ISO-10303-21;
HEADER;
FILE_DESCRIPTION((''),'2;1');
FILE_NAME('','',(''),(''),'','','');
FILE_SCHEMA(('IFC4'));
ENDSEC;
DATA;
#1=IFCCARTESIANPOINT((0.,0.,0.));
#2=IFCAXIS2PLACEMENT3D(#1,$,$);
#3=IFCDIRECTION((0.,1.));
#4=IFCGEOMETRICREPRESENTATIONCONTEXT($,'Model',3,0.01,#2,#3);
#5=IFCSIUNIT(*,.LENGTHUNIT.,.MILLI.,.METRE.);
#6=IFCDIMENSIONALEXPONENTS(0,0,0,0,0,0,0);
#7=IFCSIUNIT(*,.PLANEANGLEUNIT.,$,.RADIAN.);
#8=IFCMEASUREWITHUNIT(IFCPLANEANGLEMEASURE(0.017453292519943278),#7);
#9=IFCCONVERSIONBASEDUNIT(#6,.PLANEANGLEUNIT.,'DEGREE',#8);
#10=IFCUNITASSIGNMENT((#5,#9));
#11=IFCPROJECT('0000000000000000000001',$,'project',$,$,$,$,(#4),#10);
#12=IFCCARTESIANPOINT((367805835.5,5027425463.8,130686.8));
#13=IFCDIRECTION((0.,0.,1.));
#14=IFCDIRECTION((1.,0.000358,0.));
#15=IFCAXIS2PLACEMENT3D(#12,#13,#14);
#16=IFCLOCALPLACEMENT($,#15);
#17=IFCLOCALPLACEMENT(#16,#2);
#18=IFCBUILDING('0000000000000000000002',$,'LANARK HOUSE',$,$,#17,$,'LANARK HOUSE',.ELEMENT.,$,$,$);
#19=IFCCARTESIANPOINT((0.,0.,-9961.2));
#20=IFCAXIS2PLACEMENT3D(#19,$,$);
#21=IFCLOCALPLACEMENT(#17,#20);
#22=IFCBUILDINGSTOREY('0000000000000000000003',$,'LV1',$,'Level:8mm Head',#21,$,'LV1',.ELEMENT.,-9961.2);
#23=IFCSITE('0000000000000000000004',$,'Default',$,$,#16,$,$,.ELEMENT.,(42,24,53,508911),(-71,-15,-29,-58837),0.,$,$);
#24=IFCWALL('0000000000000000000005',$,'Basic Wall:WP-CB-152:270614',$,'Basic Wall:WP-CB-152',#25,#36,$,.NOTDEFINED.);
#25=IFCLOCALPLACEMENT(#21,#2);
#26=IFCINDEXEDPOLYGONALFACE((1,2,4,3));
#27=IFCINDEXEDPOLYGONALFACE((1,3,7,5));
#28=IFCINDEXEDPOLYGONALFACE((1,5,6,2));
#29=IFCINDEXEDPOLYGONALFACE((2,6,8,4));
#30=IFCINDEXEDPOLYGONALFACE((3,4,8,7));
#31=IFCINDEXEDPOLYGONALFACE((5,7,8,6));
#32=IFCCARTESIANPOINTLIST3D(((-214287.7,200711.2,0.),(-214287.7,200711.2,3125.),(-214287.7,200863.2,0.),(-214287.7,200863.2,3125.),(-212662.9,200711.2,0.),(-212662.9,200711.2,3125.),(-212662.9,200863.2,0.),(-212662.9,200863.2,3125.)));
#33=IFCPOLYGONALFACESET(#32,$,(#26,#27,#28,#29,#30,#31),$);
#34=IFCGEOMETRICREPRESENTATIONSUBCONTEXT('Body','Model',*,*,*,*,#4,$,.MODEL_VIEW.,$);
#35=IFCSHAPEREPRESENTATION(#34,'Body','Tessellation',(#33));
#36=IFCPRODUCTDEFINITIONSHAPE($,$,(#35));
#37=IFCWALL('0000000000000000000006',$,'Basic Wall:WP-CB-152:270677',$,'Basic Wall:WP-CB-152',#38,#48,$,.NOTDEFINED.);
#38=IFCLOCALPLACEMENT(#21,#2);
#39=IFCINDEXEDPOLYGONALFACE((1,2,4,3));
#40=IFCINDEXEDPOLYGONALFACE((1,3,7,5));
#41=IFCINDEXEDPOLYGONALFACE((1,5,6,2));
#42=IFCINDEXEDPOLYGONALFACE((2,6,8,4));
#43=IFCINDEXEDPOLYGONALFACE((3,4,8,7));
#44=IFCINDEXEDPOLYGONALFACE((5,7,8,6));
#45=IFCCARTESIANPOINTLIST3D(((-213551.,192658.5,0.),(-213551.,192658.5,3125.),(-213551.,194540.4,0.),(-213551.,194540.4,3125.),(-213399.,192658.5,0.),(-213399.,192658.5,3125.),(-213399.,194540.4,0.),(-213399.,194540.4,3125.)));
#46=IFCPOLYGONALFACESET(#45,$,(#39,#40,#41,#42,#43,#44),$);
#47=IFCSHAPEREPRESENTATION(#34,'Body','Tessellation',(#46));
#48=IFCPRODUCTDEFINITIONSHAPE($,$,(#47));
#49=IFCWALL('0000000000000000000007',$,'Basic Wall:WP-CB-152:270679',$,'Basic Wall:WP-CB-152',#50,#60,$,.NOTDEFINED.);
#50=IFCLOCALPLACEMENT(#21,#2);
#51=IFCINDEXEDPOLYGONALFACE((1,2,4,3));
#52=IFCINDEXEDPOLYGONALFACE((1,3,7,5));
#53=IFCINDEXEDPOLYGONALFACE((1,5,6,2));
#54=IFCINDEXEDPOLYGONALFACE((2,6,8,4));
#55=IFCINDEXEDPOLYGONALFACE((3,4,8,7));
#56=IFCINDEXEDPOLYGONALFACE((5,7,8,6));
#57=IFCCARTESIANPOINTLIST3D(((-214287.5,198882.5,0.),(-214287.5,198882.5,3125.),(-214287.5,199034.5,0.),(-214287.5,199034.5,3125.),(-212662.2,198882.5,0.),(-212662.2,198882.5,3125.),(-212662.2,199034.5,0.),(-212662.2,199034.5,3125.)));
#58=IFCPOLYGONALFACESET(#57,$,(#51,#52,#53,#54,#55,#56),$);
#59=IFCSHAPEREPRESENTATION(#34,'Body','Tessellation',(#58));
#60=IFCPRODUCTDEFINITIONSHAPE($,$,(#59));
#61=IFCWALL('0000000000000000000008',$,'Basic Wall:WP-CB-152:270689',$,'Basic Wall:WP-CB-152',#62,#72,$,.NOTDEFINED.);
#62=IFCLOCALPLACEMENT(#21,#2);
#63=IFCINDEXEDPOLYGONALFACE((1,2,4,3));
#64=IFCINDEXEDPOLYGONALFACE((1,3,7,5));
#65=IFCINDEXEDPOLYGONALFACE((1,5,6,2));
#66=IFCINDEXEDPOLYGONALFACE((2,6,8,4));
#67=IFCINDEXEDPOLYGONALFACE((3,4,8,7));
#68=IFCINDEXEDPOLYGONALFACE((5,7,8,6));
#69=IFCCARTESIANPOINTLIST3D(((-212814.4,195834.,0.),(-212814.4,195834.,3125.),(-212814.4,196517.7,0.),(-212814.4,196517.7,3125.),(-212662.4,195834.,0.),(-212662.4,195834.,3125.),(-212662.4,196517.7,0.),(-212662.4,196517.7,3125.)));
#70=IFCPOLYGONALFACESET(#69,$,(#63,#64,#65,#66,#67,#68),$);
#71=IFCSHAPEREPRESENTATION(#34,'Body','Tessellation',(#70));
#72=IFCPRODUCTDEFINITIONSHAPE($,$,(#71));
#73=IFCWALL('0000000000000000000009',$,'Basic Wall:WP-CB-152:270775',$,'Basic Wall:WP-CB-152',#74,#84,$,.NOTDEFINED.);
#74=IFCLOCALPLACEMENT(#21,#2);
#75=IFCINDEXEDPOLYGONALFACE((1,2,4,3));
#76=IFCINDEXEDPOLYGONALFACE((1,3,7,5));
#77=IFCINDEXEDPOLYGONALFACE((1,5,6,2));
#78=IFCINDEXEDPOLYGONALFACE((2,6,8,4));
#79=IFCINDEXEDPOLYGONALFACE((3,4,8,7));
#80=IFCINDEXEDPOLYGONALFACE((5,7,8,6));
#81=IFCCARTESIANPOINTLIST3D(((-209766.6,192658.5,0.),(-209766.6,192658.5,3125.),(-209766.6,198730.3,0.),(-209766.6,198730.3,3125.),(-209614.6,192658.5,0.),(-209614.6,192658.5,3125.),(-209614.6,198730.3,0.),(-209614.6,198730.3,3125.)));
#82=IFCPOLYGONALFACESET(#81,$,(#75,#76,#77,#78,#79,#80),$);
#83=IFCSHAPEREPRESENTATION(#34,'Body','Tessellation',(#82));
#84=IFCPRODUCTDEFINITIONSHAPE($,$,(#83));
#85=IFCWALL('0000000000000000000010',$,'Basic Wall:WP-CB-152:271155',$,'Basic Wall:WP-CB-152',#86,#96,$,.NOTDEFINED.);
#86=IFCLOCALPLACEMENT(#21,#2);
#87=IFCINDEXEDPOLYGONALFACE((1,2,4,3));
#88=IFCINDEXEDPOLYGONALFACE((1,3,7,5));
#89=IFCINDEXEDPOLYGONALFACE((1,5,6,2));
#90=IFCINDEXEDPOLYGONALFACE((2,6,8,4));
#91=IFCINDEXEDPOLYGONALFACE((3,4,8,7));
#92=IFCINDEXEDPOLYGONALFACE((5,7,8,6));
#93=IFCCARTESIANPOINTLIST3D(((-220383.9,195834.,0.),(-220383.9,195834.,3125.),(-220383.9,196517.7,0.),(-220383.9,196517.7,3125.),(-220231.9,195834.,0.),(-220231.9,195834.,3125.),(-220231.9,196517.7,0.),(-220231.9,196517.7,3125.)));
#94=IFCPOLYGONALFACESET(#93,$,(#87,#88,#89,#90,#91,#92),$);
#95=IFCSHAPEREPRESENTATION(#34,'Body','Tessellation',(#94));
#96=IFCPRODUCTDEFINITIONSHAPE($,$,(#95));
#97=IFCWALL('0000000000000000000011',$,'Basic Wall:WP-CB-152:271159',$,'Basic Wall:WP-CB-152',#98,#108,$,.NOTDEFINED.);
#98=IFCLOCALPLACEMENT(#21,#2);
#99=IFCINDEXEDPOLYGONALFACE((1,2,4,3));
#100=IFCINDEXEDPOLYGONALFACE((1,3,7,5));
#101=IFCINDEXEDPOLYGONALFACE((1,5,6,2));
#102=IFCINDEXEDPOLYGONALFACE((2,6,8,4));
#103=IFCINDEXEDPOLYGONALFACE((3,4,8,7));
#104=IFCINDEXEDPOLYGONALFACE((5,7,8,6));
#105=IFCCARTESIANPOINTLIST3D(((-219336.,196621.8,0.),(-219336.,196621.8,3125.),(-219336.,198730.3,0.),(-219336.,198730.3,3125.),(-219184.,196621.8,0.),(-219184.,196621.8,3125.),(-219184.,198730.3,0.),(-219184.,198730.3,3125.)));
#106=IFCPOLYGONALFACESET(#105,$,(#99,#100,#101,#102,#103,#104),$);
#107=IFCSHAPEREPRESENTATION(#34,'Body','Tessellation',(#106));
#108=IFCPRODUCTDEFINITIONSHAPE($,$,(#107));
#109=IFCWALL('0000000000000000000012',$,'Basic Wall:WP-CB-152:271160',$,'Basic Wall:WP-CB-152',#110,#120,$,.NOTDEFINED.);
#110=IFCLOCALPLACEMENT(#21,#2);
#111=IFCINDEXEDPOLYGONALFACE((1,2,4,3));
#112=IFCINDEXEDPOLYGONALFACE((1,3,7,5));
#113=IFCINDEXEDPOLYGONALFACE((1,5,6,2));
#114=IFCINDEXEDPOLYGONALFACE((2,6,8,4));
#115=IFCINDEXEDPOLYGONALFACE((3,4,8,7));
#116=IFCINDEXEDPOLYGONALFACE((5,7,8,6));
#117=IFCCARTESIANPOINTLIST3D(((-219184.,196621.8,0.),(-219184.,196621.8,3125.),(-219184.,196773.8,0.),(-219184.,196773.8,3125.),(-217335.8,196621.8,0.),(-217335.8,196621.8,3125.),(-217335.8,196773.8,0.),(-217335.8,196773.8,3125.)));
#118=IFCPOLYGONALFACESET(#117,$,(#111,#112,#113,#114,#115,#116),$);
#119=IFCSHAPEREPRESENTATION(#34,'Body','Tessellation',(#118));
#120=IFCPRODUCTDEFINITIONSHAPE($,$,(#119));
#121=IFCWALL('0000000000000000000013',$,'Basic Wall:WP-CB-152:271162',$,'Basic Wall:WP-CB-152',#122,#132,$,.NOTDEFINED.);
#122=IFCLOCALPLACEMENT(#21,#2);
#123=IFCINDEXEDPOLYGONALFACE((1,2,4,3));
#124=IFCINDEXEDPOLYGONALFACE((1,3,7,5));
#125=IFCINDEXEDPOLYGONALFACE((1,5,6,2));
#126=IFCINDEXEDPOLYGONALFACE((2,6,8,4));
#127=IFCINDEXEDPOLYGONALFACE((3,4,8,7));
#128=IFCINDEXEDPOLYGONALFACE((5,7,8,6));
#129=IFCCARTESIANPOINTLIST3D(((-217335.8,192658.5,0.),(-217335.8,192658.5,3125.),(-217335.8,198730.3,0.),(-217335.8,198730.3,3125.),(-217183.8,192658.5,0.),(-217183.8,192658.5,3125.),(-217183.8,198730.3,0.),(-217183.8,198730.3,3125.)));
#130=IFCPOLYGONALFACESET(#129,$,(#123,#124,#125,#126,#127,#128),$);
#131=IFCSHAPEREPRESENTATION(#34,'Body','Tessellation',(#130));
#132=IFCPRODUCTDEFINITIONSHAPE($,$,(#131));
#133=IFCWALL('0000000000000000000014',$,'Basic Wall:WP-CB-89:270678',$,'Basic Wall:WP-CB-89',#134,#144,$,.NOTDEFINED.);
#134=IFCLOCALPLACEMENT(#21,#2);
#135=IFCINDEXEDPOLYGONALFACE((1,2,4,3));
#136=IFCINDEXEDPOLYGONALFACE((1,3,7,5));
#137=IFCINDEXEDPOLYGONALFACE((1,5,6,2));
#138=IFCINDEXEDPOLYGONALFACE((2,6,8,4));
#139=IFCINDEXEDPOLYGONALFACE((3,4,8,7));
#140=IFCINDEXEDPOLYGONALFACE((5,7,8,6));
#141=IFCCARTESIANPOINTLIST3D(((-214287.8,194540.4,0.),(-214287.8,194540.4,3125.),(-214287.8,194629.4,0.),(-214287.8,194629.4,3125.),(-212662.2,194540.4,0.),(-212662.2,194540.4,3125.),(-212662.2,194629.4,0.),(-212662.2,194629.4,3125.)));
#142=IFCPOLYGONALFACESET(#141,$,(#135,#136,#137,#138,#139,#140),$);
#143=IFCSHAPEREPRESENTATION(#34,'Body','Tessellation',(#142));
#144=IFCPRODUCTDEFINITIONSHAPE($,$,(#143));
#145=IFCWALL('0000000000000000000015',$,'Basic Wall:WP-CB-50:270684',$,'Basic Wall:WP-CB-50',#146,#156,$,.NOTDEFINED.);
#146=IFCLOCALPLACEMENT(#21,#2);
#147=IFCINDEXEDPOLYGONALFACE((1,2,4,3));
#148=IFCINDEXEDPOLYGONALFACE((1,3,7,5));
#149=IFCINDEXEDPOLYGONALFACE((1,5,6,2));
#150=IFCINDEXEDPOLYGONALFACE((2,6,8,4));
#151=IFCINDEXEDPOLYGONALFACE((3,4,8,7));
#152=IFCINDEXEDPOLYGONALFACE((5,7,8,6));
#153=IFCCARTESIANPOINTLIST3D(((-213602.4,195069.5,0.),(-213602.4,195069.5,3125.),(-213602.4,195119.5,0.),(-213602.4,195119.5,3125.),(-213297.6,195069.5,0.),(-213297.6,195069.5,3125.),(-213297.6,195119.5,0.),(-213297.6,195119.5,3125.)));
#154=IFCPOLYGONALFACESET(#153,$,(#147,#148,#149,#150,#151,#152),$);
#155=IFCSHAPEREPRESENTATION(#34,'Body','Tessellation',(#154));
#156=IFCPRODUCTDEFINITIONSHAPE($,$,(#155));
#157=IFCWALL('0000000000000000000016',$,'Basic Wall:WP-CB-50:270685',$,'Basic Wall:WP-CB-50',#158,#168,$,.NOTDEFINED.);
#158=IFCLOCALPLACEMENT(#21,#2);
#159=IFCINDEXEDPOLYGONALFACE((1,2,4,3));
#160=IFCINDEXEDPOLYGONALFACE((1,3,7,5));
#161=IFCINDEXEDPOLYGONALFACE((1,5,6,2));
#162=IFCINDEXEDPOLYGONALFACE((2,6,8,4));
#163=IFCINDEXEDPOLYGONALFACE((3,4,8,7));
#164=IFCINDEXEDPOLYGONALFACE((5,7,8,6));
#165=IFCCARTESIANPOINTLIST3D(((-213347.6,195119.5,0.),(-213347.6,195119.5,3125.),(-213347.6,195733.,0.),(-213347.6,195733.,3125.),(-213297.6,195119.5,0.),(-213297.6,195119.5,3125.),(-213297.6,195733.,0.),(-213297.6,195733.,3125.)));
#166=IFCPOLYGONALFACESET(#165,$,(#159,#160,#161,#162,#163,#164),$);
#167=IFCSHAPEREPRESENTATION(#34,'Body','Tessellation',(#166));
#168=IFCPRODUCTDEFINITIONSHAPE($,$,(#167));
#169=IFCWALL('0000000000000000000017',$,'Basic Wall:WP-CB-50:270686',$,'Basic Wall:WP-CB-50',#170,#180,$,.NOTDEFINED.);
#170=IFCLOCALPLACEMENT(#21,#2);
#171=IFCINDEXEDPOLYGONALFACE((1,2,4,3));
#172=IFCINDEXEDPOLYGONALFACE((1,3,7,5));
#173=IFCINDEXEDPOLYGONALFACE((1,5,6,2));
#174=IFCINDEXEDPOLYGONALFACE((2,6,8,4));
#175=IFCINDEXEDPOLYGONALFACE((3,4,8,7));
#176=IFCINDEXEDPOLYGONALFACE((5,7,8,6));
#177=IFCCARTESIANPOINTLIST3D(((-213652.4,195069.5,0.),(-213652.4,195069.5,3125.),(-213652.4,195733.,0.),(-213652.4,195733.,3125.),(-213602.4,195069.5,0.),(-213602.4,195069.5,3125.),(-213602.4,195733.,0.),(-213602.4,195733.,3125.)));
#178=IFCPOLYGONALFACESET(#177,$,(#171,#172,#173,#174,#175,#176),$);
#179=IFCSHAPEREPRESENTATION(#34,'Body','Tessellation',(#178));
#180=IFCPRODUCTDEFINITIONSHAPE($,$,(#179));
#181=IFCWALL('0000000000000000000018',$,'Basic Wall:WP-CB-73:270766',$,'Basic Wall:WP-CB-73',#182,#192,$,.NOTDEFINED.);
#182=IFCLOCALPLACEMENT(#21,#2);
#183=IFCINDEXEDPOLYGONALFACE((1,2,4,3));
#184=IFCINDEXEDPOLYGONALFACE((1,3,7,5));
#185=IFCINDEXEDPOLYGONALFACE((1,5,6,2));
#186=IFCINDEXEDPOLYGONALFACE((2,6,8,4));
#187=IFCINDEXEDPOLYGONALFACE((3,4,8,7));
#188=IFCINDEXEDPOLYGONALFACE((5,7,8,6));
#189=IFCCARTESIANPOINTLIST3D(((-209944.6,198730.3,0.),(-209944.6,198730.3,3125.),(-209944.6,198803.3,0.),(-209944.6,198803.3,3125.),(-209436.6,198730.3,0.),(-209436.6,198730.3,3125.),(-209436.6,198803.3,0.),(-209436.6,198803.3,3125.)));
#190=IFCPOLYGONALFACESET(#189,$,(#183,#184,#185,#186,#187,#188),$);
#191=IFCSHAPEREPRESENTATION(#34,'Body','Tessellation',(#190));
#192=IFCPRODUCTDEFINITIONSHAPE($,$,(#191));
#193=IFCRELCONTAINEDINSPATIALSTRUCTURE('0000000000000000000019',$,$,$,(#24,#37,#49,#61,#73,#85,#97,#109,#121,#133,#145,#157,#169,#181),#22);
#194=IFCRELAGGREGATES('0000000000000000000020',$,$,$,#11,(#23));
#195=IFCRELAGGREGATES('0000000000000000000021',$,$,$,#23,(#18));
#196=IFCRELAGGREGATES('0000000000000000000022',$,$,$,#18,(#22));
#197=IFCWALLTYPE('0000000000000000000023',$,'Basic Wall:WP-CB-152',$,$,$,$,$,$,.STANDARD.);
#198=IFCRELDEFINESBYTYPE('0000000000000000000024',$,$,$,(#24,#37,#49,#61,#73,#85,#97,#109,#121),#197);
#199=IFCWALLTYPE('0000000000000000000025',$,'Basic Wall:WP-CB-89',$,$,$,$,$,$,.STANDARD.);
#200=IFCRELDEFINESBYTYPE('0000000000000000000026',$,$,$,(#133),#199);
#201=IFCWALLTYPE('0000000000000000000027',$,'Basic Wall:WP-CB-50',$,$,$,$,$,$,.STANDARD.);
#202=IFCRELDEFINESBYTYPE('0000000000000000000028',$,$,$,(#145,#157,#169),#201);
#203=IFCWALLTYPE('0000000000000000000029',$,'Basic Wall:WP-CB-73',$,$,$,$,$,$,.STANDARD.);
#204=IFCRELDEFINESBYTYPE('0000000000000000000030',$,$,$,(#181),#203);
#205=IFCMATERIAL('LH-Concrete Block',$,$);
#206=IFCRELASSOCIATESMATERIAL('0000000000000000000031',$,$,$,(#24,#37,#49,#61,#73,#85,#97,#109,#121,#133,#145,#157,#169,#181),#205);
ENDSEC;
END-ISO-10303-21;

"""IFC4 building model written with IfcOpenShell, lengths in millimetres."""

from ifc_helpers import new_model, entity, si_unit, converted_unit, direction, frame, origin, place, context, subcontext, project, spatial, indexed_curve, outline, extrude, material, type_object, element, save


model = new_model("IFC4")

# Units and contexts
model_context = context("Model", 3, precision=0.01, world=origin(), true_north=direction((0.0, 1.0)))
body_context = subcontext(model_context, "Body", "Model", "MODEL_VIEW")
ifc_project = project(units=[si_unit("LENGTHUNIT", "METRE", prefix="MILLI"), converted_unit("PLANEANGLEUNIT", "DEGREE", entity("IfcPlaneAngleMeasure", 0.017453292519943278), si_unit("PLANEANGLEUNIT", "RADIAN"), dimensions=[0, 0, 0, 0, 0, 0, 0])], contexts=[model_context])

# Site, building, storey
site_placement = place(None, frame((367805835.5, 5027425463.8, 130686.8), z_axis=(0.0, 0.0, 1.0), x_axis=(1.0, 0.000358, 0.0)))
site = spatial("IfcSite", under=ifc_project, at=site_placement, Name="Default", CompositionType="ELEMENT", RefLatitude=(42, 24, 53, 508911), RefLongitude=(-71, -15, -29, -58837), RefElevation=0.0)
building_placement = place(site_placement, origin())
building = spatial("IfcBuilding", under=site, at=building_placement, Name="LANARK HOUSE", LongName="LANARK HOUSE", CompositionType="ELEMENT")
storey_placement = place(building_placement, frame((0.0, 0.0, -9961.2)))
storey = spatial("IfcBuildingStorey", under=building, at=storey_placement, Name="LV1", ObjectType="Level:8mm Head", LongName="LV1", CompositionType="ELEMENT", Elevation=-9961.2)

# Walls
ifc_material_1 = material(Name="LH-Concrete Block")
wall_type_1 = type_object("IfcWallType", Name="Basic Wall:WP-CB-152", PredefinedType="STANDARD")
wall_1_placement = place(storey_placement, frame((-212662.9, 200787.2, 0.0), z_axis=(0.0, 0.0, 1.0), x_axis=(-1.0, 0.0, 0.0)))
element("IfcWall", 1, at=wall_1_placement, inside=storey, type_object=wall_type_1, material=ifc_material_1, Name="Basic Wall:WP-CB-152:270614", ObjectType="Basic Wall:WP-CB-152", PredefinedType="NOTDEFINED", context=body_context, shape_type="SweptSolid", body=[
    extrude(outline(indexed_curve([(1624.7, 76.0), (0.0, 76.0), (0.0, -76.0), (1624.7, -76.0), (1624.7, 76.0)], self_intersect=False)), origin(), (0.0, 0.0, 1.0), 3125.0),
])
wall_2_placement = place(storey_placement, frame((-213475.0, 194540.4, 0.0), z_axis=(0.0, 0.0, 1.0), x_axis=(0.0, -1.0, 0.0)))
element("IfcWall", 2, at=wall_2_placement, inside=storey, type_object=wall_type_1, material=ifc_material_1, Name="Basic Wall:WP-CB-152:270677", ObjectType="Basic Wall:WP-CB-152", PredefinedType="NOTDEFINED", context=body_context, shape_type="SweptSolid", body=[
    extrude(outline(indexed_curve([(1881.9, 76.0), (0.0, 76.0), (0.0, -76.0), (1881.9, -76.0), (1881.9, 76.0)], self_intersect=False)), origin(), (0.0, 0.0, 1.0), 3125.0),
])
wall_3_placement = place(storey_placement, frame((-214287.5, 198958.5, 0.0)))
element("IfcWall", 3, at=wall_3_placement, inside=storey, type_object=wall_type_1, material=ifc_material_1, Name="Basic Wall:WP-CB-152:270679", ObjectType="Basic Wall:WP-CB-152", PredefinedType="NOTDEFINED", context=body_context, shape_type="SweptSolid", body=[
    extrude(outline(indexed_curve([(1625.3, 76.0), (0.0, 76.0), (0.0, -76.0), (1625.3, -76.0), (1625.3, 76.0)], self_intersect=False)), origin(), (0.0, 0.0, 1.0), 3125.0),
])
wall_4_placement = place(storey_placement, frame((-212738.4, 196517.7, 0.0), z_axis=(0.0, 0.0, 1.0), x_axis=(0.0, -1.0, 0.0)))
element("IfcWall", 4, at=wall_4_placement, inside=storey, type_object=wall_type_1, material=ifc_material_1, Name="Basic Wall:WP-CB-152:270689", ObjectType="Basic Wall:WP-CB-152", PredefinedType="NOTDEFINED", context=body_context, shape_type="SweptSolid", body=[
    extrude(outline(indexed_curve([(683.7, 76.0), (0.0, 76.0), (0.0, -76.0), (683.7, -76.0), (683.7, 76.0)], self_intersect=False)), origin(), (0.0, 0.0, 1.0), 3125.0),
])
wall_5_placement = place(storey_placement, frame((-209690.6, 192658.5, 0.0), z_axis=(0.0, 0.0, 1.0), x_axis=(0.0, 1.0, 0.0)))
element("IfcWall", 5, at=wall_5_placement, inside=storey, type_object=wall_type_1, material=ifc_material_1, Name="Basic Wall:WP-CB-152:270775", ObjectType="Basic Wall:WP-CB-152", PredefinedType="NOTDEFINED", context=body_context, shape_type="SweptSolid", body=[
    extrude(outline(indexed_curve([(6071.8, 76.0), (0.0, 76.0), (0.0, -76.0), (6071.8, -76.0), (6071.8, 76.0)], self_intersect=False)), origin(), (0.0, 0.0, 1.0), 3125.0),
])
wall_6_placement = place(storey_placement, frame((-220307.9, 196517.7, 0.0), z_axis=(0.0, 0.0, 1.0), x_axis=(0.0, -1.0, 0.0)))
element("IfcWall", 6, at=wall_6_placement, inside=storey, type_object=wall_type_1, material=ifc_material_1, Name="Basic Wall:WP-CB-152:271155", ObjectType="Basic Wall:WP-CB-152", PredefinedType="NOTDEFINED", context=body_context, shape_type="SweptSolid", body=[
    extrude(outline(indexed_curve([(683.7, 76.0), (0.0, 76.0), (0.0, -76.0), (683.7, -76.0), (683.7, 76.0)], self_intersect=False)), origin(), (0.0, 0.0, 1.0), 3125.0),
])
wall_7_placement = place(storey_placement, frame((-219260.0, 198730.3, 0.0), z_axis=(0.0, 0.0, 1.0), x_axis=(0.0, -1.0, 0.0)))
element("IfcWall", 7, at=wall_7_placement, inside=storey, type_object=wall_type_1, material=ifc_material_1, Name="Basic Wall:WP-CB-152:271159", ObjectType="Basic Wall:WP-CB-152", PredefinedType="NOTDEFINED", context=body_context, shape_type="SweptSolid", body=[
    extrude(outline(indexed_curve([(2108.4, 76.0), (0.0, 76.0), (0.0, -76.0), (2108.4, -76.0), (2108.4, 76.0)], self_intersect=False)), origin(), (0.0, 0.0, 1.0), 3125.0),
])
wall_8_placement = place(storey_placement, frame((-219184.0, 196697.8, 0.0)))
element("IfcWall", 8, at=wall_8_placement, inside=storey, type_object=wall_type_1, material=ifc_material_1, Name="Basic Wall:WP-CB-152:271160", ObjectType="Basic Wall:WP-CB-152", PredefinedType="NOTDEFINED", context=body_context, shape_type="SweptSolid", body=[
    extrude(outline(indexed_curve([(1848.2, 76.0), (0.0, 76.0), (0.0, -76.0), (1848.2, -76.0), (1848.2, 76.0)], self_intersect=False)), origin(), (0.0, 0.0, 1.0), 3125.0),
])
wall_9_placement = place(storey_placement, frame((-217259.8, 198730.3, 0.0), z_axis=(0.0, 0.0, 1.0), x_axis=(0.0, -1.0, 0.0)))
element("IfcWall", 9, at=wall_9_placement, inside=storey, type_object=wall_type_1, material=ifc_material_1, Name="Basic Wall:WP-CB-152:271162", ObjectType="Basic Wall:WP-CB-152", PredefinedType="NOTDEFINED", context=body_context, shape_type="SweptSolid", body=[
    extrude(outline(indexed_curve([(6071.8, 76.0), (0.0, 76.0), (0.0, -76.0), (6071.8, -76.0), (6071.8, 76.0)], self_intersect=False)), origin(), (0.0, 0.0, 1.0), 3125.0),
])
wall_type_2 = type_object("IfcWallType", Name="Basic Wall:WP-CB-89", PredefinedType="STANDARD")
wall_10_placement = place(storey_placement, frame((-214287.8, 194584.9, 0.0)))
element("IfcWall", 10, at=wall_10_placement, inside=storey, type_object=wall_type_2, material=ifc_material_1, Name="Basic Wall:WP-CB-89:270678", ObjectType="Basic Wall:WP-CB-89", PredefinedType="NOTDEFINED", context=body_context, shape_type="SweptSolid", body=[
    extrude(outline(indexed_curve([(1625.6, 44.5), (0.0, 44.5), (0.0, -44.5), (1625.6, -44.5), (1625.6, 44.5)], self_intersect=False)), origin(), (0.0, 0.0, 1.0), 3125.0),
])
wall_type_3 = type_object("IfcWallType", Name="Basic Wall:WP-CB-50", PredefinedType="STANDARD")
wall_11_placement = place(storey_placement, frame((-213297.6, 195094.5, 0.0), z_axis=(0.0, 0.0, 1.0), x_axis=(-1.0, 0.0, 0.0)))
element("IfcWall", 11, at=wall_11_placement, inside=storey, type_object=wall_type_3, material=ifc_material_1, Name="Basic Wall:WP-CB-50:270684", ObjectType="Basic Wall:WP-CB-50", PredefinedType="NOTDEFINED", context=body_context, shape_type="SweptSolid", body=[
    extrude(outline(indexed_curve([(304.8, 25.0), (0.0, 25.0), (0.0, -25.0), (304.8, -25.0), (304.8, 25.0)], self_intersect=False)), origin(), (0.0, 0.0, 1.0), 3125.0),
])
wall_12_placement = place(storey_placement, frame((-213322.6, 195733.0, 0.0), z_axis=(0.0, 0.0, 1.0), x_axis=(0.0, -1.0, 0.0)))
element("IfcWall", 12, at=wall_12_placement, inside=storey, type_object=wall_type_3, material=ifc_material_1, Name="Basic Wall:WP-CB-50:270685", ObjectType="Basic Wall:WP-CB-50", PredefinedType="NOTDEFINED", context=body_context, shape_type="SweptSolid", body=[
    extrude(outline(indexed_curve([(613.5, 25.0), (0.0, 25.0), (0.0, -25.0), (613.5, -25.0), (613.5, 25.0)], self_intersect=False)), origin(), (0.0, 0.0, 1.0), 3125.0),
])
wall_13_placement = place(storey_placement, frame((-213627.4, 195733.0, 0.0), z_axis=(0.0, 0.0, 1.0), x_axis=(0.0, -1.0, 0.0)))
element("IfcWall", 13, at=wall_13_placement, inside=storey, type_object=wall_type_3, material=ifc_material_1, Name="Basic Wall:WP-CB-50:270686", ObjectType="Basic Wall:WP-CB-50", PredefinedType="NOTDEFINED", context=body_context, shape_type="SweptSolid", body=[
    extrude(outline(indexed_curve([(663.5, 25.0), (0.0, 25.0), (0.0, -25.0), (663.5, -25.0), (663.5, 25.0)], self_intersect=False)), origin(), (0.0, 0.0, 1.0), 3125.0),
])
wall_type_4 = type_object("IfcWallType", Name="Basic Wall:WP-CB-73", PredefinedType="STANDARD")
wall_14_placement = place(storey_placement, frame((-209436.6, 198766.8, 0.0), z_axis=(0.0, 0.0, 1.0), x_axis=(-1.0, 0.0, 0.0)))
element("IfcWall", 14, at=wall_14_placement, inside=storey, type_object=wall_type_4, material=ifc_material_1, Name="Basic Wall:WP-CB-73:270766", ObjectType="Basic Wall:WP-CB-73", PredefinedType="NOTDEFINED", context=body_context, shape_type="SweptSolid", body=[
    extrude(outline(indexed_curve([(508.0, 36.5), (0.0, 36.5), (0.0, -36.5), (508.0, -36.5), (508.0, 36.5)], self_intersect=False)), origin(), (0.0, 0.0, 1.0), 3125.0),
])

save(model, "model.ifc")
